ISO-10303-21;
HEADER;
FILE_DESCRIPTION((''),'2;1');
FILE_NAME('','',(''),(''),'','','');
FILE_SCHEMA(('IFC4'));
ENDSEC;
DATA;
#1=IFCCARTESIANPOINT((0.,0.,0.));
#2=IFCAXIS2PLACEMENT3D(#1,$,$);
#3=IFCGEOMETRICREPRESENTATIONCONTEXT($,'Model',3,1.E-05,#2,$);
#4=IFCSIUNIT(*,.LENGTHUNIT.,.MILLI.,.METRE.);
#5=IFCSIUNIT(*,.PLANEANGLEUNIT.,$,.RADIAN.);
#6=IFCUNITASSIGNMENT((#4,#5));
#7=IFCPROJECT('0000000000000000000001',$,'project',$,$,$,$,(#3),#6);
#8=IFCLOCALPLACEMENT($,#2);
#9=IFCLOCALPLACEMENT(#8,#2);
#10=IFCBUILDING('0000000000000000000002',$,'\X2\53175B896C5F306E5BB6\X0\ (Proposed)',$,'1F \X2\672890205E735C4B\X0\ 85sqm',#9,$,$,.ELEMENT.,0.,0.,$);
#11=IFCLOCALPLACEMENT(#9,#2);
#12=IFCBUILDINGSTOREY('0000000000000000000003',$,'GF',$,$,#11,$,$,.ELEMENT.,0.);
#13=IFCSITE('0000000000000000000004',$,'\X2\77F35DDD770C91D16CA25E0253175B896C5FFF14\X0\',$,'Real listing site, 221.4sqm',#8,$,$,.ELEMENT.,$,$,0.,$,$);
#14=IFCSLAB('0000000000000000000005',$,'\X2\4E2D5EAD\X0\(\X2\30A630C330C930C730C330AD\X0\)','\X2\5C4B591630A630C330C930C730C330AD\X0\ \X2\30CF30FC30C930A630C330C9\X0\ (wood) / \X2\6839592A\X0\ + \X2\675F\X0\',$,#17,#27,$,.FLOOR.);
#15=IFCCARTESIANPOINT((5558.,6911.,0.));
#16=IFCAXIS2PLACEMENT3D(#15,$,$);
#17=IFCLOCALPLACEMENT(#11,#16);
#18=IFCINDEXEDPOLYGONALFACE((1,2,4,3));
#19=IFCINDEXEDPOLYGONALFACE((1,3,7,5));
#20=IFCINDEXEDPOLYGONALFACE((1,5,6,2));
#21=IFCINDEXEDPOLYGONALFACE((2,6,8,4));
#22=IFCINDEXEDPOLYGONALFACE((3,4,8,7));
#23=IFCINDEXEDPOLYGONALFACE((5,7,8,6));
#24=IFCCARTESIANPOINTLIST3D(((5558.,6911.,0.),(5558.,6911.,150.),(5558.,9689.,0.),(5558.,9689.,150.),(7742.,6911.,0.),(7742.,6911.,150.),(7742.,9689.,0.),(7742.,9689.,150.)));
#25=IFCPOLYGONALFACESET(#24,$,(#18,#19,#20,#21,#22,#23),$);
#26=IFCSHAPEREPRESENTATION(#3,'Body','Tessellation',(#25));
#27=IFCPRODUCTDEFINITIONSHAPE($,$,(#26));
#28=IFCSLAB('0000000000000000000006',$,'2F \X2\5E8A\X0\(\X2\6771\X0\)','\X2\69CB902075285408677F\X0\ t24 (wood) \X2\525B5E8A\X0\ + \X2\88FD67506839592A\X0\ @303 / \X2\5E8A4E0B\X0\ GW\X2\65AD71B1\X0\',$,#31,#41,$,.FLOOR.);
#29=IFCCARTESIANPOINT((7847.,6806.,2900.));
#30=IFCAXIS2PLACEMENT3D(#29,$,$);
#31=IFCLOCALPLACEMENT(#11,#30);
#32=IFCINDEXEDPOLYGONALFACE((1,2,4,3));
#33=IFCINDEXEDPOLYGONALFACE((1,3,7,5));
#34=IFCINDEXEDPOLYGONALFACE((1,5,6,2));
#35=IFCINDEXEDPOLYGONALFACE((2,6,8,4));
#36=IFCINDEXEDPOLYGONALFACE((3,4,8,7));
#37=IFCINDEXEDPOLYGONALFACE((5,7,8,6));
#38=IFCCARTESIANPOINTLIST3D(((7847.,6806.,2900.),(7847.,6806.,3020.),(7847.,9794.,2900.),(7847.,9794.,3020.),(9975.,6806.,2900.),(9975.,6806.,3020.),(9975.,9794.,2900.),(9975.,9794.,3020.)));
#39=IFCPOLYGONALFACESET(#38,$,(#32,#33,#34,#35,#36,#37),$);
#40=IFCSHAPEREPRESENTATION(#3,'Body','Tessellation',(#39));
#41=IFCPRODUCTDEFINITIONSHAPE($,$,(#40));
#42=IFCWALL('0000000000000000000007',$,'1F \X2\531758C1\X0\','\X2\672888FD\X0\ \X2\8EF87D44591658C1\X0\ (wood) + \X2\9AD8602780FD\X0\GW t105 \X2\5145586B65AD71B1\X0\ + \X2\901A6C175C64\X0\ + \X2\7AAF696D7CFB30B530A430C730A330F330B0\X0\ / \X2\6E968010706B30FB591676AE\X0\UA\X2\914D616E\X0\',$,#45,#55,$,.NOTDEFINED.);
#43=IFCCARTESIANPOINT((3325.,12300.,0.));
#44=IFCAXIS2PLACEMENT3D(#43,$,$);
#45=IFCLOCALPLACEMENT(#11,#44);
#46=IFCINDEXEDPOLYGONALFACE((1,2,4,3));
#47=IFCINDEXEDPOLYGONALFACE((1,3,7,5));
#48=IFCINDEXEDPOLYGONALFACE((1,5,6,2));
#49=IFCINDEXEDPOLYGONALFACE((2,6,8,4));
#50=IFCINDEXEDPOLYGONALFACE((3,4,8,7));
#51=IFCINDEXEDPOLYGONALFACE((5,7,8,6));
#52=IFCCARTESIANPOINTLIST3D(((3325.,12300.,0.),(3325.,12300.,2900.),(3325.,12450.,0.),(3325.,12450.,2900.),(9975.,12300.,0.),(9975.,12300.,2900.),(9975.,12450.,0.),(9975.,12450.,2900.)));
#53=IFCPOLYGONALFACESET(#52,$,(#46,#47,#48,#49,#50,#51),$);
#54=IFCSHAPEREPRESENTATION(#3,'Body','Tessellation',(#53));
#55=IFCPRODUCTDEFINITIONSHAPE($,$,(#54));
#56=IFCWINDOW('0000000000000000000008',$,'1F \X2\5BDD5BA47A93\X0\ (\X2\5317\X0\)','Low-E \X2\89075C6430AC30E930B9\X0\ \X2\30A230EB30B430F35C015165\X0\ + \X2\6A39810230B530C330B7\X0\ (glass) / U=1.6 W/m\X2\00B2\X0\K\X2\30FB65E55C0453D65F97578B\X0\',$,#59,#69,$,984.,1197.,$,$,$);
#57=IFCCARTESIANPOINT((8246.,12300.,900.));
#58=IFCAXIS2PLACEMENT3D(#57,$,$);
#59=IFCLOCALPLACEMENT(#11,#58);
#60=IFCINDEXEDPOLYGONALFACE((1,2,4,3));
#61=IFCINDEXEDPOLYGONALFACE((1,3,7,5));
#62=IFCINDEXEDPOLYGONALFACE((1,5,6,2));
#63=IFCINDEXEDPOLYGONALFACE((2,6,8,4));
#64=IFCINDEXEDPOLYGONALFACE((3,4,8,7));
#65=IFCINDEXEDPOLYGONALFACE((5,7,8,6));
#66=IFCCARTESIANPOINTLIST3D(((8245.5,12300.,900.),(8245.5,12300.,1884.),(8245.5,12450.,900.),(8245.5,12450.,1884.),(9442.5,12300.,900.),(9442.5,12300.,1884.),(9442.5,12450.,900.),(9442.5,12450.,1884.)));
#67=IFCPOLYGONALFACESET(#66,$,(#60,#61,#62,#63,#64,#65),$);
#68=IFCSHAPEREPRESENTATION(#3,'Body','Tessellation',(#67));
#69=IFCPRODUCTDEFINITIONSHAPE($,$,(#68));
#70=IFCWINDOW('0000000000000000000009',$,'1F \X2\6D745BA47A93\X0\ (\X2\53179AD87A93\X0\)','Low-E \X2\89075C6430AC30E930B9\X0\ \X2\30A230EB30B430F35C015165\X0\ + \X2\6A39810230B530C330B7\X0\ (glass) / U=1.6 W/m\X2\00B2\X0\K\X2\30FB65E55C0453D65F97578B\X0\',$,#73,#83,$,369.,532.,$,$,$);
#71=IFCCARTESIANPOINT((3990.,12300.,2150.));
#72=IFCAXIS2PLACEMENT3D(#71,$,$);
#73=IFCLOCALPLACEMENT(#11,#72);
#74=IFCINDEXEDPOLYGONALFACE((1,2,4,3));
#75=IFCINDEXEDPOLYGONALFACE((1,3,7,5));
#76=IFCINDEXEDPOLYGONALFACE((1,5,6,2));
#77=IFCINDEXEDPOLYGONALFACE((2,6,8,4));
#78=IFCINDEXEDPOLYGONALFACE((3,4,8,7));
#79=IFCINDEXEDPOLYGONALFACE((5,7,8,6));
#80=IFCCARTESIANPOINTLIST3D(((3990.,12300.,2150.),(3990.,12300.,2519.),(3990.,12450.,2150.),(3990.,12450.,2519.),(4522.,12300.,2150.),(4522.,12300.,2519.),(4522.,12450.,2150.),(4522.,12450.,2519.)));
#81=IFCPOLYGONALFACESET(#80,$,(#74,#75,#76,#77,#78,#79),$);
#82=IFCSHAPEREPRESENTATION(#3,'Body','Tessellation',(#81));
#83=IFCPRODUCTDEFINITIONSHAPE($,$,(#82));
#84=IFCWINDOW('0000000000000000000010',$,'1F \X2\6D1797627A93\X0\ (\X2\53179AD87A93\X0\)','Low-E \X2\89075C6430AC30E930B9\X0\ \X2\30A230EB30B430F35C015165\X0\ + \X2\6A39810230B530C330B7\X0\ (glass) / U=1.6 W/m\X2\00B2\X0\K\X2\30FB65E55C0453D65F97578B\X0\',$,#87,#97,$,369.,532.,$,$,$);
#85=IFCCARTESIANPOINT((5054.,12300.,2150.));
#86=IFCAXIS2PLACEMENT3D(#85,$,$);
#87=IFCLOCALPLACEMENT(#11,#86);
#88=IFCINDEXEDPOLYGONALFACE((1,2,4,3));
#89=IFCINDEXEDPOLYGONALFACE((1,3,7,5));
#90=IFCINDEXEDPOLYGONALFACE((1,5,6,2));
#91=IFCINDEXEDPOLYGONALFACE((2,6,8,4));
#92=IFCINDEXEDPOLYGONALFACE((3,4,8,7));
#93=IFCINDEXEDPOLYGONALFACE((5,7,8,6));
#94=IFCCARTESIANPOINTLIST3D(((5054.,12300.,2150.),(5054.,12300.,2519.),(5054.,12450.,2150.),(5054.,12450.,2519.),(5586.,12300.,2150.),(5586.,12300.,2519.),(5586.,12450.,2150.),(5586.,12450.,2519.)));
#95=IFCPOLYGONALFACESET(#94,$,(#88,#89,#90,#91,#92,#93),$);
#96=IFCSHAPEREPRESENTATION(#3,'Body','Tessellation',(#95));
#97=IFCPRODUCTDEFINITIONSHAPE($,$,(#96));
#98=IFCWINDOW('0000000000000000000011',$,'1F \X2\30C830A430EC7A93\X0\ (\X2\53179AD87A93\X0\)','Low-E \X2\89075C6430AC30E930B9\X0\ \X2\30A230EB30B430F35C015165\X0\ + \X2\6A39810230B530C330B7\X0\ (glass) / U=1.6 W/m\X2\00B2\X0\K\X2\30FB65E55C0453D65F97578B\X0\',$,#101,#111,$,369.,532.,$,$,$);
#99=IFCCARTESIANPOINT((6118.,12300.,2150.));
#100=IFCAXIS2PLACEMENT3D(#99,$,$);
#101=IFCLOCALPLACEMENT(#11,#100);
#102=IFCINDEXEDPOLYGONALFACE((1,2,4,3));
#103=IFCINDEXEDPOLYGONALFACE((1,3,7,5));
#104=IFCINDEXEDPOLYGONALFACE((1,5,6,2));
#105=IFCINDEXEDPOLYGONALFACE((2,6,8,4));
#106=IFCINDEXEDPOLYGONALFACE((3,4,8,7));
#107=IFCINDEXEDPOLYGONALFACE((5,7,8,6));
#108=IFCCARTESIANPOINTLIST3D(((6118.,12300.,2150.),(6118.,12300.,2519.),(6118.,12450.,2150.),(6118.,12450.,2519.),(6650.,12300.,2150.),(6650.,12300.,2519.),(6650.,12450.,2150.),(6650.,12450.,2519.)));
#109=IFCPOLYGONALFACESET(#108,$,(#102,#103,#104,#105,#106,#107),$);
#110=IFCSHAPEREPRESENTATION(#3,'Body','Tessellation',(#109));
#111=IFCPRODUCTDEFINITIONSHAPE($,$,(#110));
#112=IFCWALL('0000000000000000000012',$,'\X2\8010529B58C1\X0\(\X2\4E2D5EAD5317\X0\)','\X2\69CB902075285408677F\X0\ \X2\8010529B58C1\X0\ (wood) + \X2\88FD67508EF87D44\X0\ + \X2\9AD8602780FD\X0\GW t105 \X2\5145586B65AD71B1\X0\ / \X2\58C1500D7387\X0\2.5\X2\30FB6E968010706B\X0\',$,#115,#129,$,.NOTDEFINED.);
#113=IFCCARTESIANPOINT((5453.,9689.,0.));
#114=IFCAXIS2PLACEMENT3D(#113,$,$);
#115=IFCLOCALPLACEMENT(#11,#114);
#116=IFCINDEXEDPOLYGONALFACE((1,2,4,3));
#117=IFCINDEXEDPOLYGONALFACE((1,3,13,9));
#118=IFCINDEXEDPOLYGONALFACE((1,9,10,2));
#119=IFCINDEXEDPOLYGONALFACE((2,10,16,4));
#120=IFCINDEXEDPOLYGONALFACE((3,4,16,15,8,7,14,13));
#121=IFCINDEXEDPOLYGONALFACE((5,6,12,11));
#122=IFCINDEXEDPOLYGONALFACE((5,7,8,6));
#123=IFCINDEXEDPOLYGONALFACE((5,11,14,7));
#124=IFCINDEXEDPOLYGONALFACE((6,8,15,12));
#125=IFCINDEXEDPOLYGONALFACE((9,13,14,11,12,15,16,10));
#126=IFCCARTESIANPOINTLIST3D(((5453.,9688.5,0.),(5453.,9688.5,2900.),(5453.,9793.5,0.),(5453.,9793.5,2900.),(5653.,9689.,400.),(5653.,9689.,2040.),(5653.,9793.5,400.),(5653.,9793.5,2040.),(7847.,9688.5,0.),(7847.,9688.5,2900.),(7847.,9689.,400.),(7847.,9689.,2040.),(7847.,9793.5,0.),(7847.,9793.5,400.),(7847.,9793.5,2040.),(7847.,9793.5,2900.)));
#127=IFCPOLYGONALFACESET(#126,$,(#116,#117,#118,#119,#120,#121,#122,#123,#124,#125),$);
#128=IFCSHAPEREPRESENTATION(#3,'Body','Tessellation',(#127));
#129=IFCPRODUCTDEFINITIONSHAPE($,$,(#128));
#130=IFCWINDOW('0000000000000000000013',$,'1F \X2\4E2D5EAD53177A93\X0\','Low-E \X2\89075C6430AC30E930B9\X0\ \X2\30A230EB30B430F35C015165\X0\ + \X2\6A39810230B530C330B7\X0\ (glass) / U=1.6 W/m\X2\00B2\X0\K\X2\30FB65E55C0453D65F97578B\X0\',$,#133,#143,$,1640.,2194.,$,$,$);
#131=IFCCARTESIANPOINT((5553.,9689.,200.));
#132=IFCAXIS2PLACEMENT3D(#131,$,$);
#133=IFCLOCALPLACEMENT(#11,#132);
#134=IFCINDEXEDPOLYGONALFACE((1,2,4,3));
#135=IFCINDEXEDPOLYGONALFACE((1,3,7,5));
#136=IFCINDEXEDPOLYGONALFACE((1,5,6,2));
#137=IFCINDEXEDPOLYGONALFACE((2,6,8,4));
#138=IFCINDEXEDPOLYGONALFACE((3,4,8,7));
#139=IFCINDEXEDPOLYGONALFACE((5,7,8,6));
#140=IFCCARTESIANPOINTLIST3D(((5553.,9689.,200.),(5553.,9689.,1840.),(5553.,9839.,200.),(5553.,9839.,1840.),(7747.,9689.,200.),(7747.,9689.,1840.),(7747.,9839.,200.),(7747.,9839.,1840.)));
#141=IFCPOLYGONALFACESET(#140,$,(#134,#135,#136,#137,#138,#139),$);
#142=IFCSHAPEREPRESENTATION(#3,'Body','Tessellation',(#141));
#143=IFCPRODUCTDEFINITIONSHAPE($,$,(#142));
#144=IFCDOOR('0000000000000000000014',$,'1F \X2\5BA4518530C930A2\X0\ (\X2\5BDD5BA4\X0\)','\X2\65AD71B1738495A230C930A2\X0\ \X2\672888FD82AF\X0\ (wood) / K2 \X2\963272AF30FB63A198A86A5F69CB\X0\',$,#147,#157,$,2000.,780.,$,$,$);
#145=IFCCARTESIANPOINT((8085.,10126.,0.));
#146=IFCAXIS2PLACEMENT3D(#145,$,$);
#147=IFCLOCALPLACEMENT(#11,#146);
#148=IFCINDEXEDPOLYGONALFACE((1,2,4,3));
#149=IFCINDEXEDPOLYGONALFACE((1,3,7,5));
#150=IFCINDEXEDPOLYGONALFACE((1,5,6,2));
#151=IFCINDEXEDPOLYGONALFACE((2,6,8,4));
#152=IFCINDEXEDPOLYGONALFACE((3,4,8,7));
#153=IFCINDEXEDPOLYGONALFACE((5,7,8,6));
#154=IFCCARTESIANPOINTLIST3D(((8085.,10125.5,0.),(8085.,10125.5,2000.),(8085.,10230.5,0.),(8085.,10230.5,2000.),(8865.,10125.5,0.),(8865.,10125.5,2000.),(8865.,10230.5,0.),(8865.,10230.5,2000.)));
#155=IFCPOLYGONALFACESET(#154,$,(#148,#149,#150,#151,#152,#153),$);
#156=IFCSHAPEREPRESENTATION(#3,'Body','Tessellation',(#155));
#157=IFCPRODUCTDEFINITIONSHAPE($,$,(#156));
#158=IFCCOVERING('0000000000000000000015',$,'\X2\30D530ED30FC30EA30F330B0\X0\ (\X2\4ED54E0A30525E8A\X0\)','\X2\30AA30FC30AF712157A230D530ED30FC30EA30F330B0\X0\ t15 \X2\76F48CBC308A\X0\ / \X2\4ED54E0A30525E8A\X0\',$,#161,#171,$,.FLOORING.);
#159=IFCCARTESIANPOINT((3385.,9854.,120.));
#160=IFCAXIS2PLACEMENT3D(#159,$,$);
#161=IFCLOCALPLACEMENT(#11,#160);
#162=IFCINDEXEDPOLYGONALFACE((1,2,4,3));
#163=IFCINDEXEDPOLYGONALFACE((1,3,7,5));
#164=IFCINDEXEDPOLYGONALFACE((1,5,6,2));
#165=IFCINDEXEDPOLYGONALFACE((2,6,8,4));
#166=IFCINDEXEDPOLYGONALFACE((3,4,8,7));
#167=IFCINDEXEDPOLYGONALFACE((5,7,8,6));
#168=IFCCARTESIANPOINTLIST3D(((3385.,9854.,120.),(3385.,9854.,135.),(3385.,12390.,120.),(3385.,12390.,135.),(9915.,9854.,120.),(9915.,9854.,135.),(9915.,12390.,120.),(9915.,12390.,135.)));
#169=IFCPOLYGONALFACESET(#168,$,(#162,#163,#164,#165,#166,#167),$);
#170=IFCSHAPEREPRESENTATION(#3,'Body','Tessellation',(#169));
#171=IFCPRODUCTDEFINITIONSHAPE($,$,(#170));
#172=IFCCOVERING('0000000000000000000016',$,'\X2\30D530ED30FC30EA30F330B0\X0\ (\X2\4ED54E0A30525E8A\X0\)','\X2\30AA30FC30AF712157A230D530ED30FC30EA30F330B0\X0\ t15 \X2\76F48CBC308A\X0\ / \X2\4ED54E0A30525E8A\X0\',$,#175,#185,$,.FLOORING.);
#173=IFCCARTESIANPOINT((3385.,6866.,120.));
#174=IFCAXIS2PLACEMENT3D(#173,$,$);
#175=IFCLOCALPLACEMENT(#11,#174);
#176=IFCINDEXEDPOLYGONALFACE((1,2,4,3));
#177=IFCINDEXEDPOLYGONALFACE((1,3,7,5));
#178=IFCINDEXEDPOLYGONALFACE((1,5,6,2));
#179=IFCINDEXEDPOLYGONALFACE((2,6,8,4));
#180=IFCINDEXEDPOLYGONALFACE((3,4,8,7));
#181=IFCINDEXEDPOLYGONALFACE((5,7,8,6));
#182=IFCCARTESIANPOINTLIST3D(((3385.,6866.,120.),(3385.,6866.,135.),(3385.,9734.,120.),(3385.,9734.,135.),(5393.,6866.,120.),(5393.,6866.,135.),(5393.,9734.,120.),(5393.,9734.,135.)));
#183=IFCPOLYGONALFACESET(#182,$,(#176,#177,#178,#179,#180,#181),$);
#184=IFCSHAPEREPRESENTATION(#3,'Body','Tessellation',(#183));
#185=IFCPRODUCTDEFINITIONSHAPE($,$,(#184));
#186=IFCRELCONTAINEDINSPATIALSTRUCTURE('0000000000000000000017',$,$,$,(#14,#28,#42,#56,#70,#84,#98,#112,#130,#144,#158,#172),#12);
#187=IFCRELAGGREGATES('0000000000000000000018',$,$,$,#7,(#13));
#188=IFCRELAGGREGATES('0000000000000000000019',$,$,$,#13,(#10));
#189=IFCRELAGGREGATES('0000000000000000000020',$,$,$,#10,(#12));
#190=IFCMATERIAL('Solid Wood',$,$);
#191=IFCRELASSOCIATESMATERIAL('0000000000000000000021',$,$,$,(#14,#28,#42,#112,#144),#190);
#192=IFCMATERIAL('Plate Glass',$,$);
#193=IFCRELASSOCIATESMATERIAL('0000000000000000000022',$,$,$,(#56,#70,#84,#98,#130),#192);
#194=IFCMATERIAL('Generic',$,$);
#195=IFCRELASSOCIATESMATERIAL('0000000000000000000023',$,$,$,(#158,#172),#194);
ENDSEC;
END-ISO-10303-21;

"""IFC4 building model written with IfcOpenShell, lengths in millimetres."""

from ifc_helpers import new_model, si_unit, frame, frame_2d, origin, place, context, project, spatial, rectangle, extrude, material, element, fill, save


model = new_model("IFC4")

# Units and contexts
model_context = context("Model", 3, precision=1e-05, world=origin())
ifc_project = project(units=[si_unit("LENGTHUNIT", "METRE", prefix="MILLI"), si_unit("PLANEANGLEUNIT", "RADIAN")], contexts=[model_context])

# Site, building, storey
site_placement = place(None, origin())
site = spatial("IfcSite", under=ifc_project, at=site_placement, Name="石川県金沢市北安江４", ObjectType="Real listing site, 221.4sqm", CompositionType="ELEMENT", RefElevation=0.0)
building_placement = place(site_placement, origin())
building = spatial("IfcBuilding", under=site, at=building_placement, Name="北安江の家 (Proposed)", ObjectType="1F 木造平屋 85sqm", CompositionType="ELEMENT", ElevationOfRefHeight=0.0, ElevationOfTerrain=0.0)
storey_placement = place(building_placement, origin())
storey = spatial("IfcBuildingStorey", under=building, at=storey_placement, Name="GF", CompositionType="ELEMENT", Elevation=0.0)

# Slabs
ifc_material_1 = material(Name="Solid Wood")
slab_1_placement = place(storey_placement, frame((5558.0, 6911.0, 0.0)))
element("IfcSlab", 1, at=slab_1_placement, inside=storey, material=ifc_material_1, Name="中庭(ウッドデッキ)", Description="屋外ウッドデッキ ハードウッド (wood) / 根太 + 束", PredefinedType="FLOOR", context=model_context, shape_type="SweptSolid", body=[
    extrude(rectangle(XDim=2184.0, YDim=2778.0, at=frame_2d((1092.0, 1389.0))), frame((5558.0, 6911.0, 0.0)), (0.0, 0.0, 1.0), 150.0),
])
slab_2_placement = place(storey_placement, frame((7847.0, 6806.0, 2900.0)))
element("IfcSlab", 2, at=slab_2_placement, inside=storey, material=ifc_material_1, Name="2F 床(東)", Description="構造用合板 t24 (wood) 剛床 + 製材根太 @303 / 床下 GW断熱", PredefinedType="FLOOR", context=model_context, shape_type="SweptSolid", body=[
    extrude(rectangle(XDim=2128.0, YDim=2988.0, at=frame_2d((1064.0, 1494.0))), frame((7847.0, 6806.0, 2900.0)), (0.0, 0.0, 1.0), 120.0),
])

# Wall, openings, windows
wall_1_placement = place(storey_placement, frame((3325.0, 12300.0, 0.0)))
wall_1 = element("IfcWall", 3, at=wall_1_placement, inside=storey, material=ifc_material_1, Name="1F 北壁", Description="木製 軸組外壁 (wood) + 高性能GW t105 充填断熱 + 通気層 + 窯業系サイディング / 準耐火・外皮UA配慮", PredefinedType="NOTDEFINED", context=model_context, shape_type="SweptSolid", body=[
    extrude(rectangle(XDim=6650.0, YDim=150.0, at=frame_2d((3325.0, 75.0))), frame((3325.0, 12300.0, 0.0)), (0.0, 0.0, 1.0), 2900.0),
])
opening_1_placement = place(storey_placement, frame((8246.0, 12300.0, 900.0)))
opening_1 = element("IfcOpeningElement", 4, at=opening_1_placement, cuts=wall_1, PredefinedType="NOTDEFINED", context=model_context, shape_type="SweptSolid", body=[
    extrude(rectangle(XDim=1197.0, YDim=150.0, at=frame_2d((598.0, 75.0))), frame((8246.0, 12300.0, 900.0)), (0.0, 0.0, 1.0), 984.0),
])
opening_2_placement = place(storey_placement, frame((3990.0, 12300.0, 2150.0)))
opening_2 = element("IfcOpeningElement", 5, at=opening_2_placement, cuts=wall_1, PredefinedType="NOTDEFINED", context=model_context, shape_type="SweptSolid", body=[
    extrude(rectangle(XDim=532.0, YDim=150.0, at=frame_2d((266.0, 75.0))), frame((3990.0, 12300.0, 2150.0)), (0.0, 0.0, 1.0), 369.0),
])
opening_3_placement = place(storey_placement, frame((5054.0, 12300.0, 2150.0)))
opening_3 = element("IfcOpeningElement", 6, at=opening_3_placement, cuts=wall_1, PredefinedType="NOTDEFINED", context=model_context, shape_type="SweptSolid", body=[
    extrude(rectangle(XDim=532.0, YDim=150.0, at=frame_2d((266.0, 75.0))), frame((5054.0, 12300.0, 2150.0)), (0.0, 0.0, 1.0), 369.0),
])
opening_4_placement = place(storey_placement, frame((6118.0, 12300.0, 2150.0)))
opening_4 = element("IfcOpeningElement", 7, at=opening_4_placement, cuts=wall_1, PredefinedType="NOTDEFINED", context=model_context, shape_type="SweptSolid", body=[
    extrude(rectangle(XDim=532.0, YDim=150.0, at=frame_2d((266.0, 75.0))), frame((6118.0, 12300.0, 2150.0)), (0.0, 0.0, 1.0), 369.0),
])
ifc_material_2 = material(Name="Plate Glass")
window_1_placement = place(storey_placement, frame((8246.0, 12300.0, 900.0)))
window_1 = element("IfcWindow", 8, at=window_1_placement, inside=storey, material=ifc_material_2, Name="1F 寝室窓 (北)", Description="Low-E 複層ガラス アルゴン封入 + 樹脂サッシ (glass) / U=1.6 W/m²K・日射取得型", OverallHeight=984.0, OverallWidth=1197.0, context=model_context, shape_type="SweptSolid", body=[
    extrude(rectangle(XDim=1197.0, YDim=150.0, at=frame_2d((598.0, 75.0))), frame((8246.0, 12300.0, 900.0)), (0.0, 0.0, 1.0), 984.0),
])
fill(opening_1, window_1)
window_2_placement = place(storey_placement, frame((3990.0, 12300.0, 2150.0)))
window_2 = element("IfcWindow", 9, at=window_2_placement, inside=storey, material=ifc_material_2, Name="1F 浴室窓 (北高窓)", Description="Low-E 複層ガラス アルゴン封入 + 樹脂サッシ (glass) / U=1.6 W/m²K・日射取得型", OverallHeight=369.0, OverallWidth=532.0, context=model_context, shape_type="SweptSolid", body=[
    extrude(rectangle(XDim=532.0, YDim=150.0, at=frame_2d((266.0, 75.0))), frame((3990.0, 12300.0, 2150.0)), (0.0, 0.0, 1.0), 369.0),
])
fill(opening_2, window_2)
window_3_placement = place(storey_placement, frame((5054.0, 12300.0, 2150.0)))
window_3 = element("IfcWindow", 10, at=window_3_placement, inside=storey, material=ifc_material_2, Name="1F 洗面窓 (北高窓)", Description="Low-E 複層ガラス アルゴン封入 + 樹脂サッシ (glass) / U=1.6 W/m²K・日射取得型", OverallHeight=369.0, OverallWidth=532.0, context=model_context, shape_type="SweptSolid", body=[
    extrude(rectangle(XDim=532.0, YDim=150.0, at=frame_2d((266.0, 75.0))), frame((5054.0, 12300.0, 2150.0)), (0.0, 0.0, 1.0), 369.0),
])
fill(opening_3, window_3)
window_4_placement = place(storey_placement, frame((6118.0, 12300.0, 2150.0)))
window_4 = element("IfcWindow", 11, at=window_4_placement, inside=storey, material=ifc_material_2, Name="1F トイレ窓 (北高窓)", Description="Low-E 複層ガラス アルゴン封入 + 樹脂サッシ (glass) / U=1.6 W/m²K・日射取得型", OverallHeight=369.0, OverallWidth=532.0, context=model_context, shape_type="SweptSolid", body=[
    extrude(rectangle(XDim=532.0, YDim=150.0, at=frame_2d((266.0, 75.0))), frame((6118.0, 12300.0, 2150.0)), (0.0, 0.0, 1.0), 369.0),
])
fill(opening_4, window_4)

# Wall, opening, window
wall_2_placement = place(storey_placement, frame((5453.0, 9689.0, 0.0)))
wall_2 = element("IfcWall", 12, at=wall_2_placement, inside=storey, material=ifc_material_1, Name="耐力壁(中庭北)", Description="構造用合板 耐力壁 (wood) + 製材軸組 + 高性能GW t105 充填断熱 / 壁倍率2.5・準耐火", PredefinedType="NOTDEFINED", context=model_context, shape_type="SweptSolid", body=[
    extrude(rectangle(XDim=2394.0, YDim=105.0, at=frame_2d((1197.0, 52.0))), frame((5453.0, 9689.0, 0.0)), (0.0, 0.0, 1.0), 2900.0),
])
opening_5_placement = place(storey_placement, frame((5553.0, 9689.0, 200.0)))
opening_5 = element("IfcOpeningElement", 13, at=opening_5_placement, cuts=wall_2, PredefinedType="NOTDEFINED", context=model_context, shape_type="SweptSolid", body=[
    extrude(rectangle(XDim=2194.0, YDim=150.0, at=frame_2d((1097.0, 75.0))), frame((5553.0, 9689.0, 200.0)), (0.0, 0.0, 1.0), 1640.0),
])
window_5_placement = place(storey_placement, frame((5553.0, 9689.0, 200.0)))
window_5 = element("IfcWindow", 14, at=window_5_placement, inside=storey, material=ifc_material_2, Name="1F 中庭北窓", Description="Low-E 複層ガラス アルゴン封入 + 樹脂サッシ (glass) / U=1.6 W/m²K・日射取得型", OverallHeight=1640.0, OverallWidth=2194.0, context=model_context, shape_type="SweptSolid", body=[
    extrude(rectangle(XDim=2194.0, YDim=150.0, at=frame_2d((1097.0, 75.0))), frame((5553.0, 9689.0, 200.0)), (0.0, 0.0, 1.0), 1640.0),
])
fill(opening_5, window_5)

# Door
door_1_placement = place(storey_placement, frame((8085.0, 10126.0, 0.0)))
element("IfcDoor", 15, at=door_1_placement, inside=storey, material=ifc_material_1, Name="1F 室内ドア (寝室)", Description="断熱玄関ドア 木製芯 (wood) / K2 防犯・採風機構", OverallHeight=2000.0, OverallWidth=780.0, context=model_context, shape_type="SweptSolid", body=[
    extrude(rectangle(XDim=780.0, YDim=105.0, at=frame_2d((390.0, 52.0))), frame((8085.0, 10126.0, 0.0)), (0.0, 0.0, 1.0), 2000.0),
])

# Coverings
ifc_material_3 = material(Name="Generic")
covering_1_placement = place(storey_placement, frame((3385.0, 9854.0, 120.0)))
element("IfcCovering", 16, at=covering_1_placement, inside=storey, material=ifc_material_3, Name="フローリング (仕上げ床)", Description="オーク無垢フローリング t15 直貼り / 仕上げ床", PredefinedType="FLOORING", context=model_context, shape_type="SweptSolid", body=[
    extrude(rectangle(XDim=6530.0, YDim=2536.0, at=frame_2d((3265.0, 1268.0))), frame((3385.0, 9854.0, 120.0)), (0.0, 0.0, 1.0), 15.0),
])
covering_2_placement = place(storey_placement, frame((3385.0, 6866.0, 120.0)))
element("IfcCovering", 17, at=covering_2_placement, inside=storey, material=ifc_material_3, Name="フローリング (仕上げ床)", Description="オーク無垢フローリング t15 直貼り / 仕上げ床", PredefinedType="FLOORING", context=model_context, shape_type="SweptSolid", body=[
    extrude(rectangle(XDim=2008.0, YDim=2868.0, at=frame_2d((1004.0, 1434.0))), frame((3385.0, 6866.0, 120.0)), (0.0, 0.0, 1.0), 15.0),
])

save(model, "model.ifc")
